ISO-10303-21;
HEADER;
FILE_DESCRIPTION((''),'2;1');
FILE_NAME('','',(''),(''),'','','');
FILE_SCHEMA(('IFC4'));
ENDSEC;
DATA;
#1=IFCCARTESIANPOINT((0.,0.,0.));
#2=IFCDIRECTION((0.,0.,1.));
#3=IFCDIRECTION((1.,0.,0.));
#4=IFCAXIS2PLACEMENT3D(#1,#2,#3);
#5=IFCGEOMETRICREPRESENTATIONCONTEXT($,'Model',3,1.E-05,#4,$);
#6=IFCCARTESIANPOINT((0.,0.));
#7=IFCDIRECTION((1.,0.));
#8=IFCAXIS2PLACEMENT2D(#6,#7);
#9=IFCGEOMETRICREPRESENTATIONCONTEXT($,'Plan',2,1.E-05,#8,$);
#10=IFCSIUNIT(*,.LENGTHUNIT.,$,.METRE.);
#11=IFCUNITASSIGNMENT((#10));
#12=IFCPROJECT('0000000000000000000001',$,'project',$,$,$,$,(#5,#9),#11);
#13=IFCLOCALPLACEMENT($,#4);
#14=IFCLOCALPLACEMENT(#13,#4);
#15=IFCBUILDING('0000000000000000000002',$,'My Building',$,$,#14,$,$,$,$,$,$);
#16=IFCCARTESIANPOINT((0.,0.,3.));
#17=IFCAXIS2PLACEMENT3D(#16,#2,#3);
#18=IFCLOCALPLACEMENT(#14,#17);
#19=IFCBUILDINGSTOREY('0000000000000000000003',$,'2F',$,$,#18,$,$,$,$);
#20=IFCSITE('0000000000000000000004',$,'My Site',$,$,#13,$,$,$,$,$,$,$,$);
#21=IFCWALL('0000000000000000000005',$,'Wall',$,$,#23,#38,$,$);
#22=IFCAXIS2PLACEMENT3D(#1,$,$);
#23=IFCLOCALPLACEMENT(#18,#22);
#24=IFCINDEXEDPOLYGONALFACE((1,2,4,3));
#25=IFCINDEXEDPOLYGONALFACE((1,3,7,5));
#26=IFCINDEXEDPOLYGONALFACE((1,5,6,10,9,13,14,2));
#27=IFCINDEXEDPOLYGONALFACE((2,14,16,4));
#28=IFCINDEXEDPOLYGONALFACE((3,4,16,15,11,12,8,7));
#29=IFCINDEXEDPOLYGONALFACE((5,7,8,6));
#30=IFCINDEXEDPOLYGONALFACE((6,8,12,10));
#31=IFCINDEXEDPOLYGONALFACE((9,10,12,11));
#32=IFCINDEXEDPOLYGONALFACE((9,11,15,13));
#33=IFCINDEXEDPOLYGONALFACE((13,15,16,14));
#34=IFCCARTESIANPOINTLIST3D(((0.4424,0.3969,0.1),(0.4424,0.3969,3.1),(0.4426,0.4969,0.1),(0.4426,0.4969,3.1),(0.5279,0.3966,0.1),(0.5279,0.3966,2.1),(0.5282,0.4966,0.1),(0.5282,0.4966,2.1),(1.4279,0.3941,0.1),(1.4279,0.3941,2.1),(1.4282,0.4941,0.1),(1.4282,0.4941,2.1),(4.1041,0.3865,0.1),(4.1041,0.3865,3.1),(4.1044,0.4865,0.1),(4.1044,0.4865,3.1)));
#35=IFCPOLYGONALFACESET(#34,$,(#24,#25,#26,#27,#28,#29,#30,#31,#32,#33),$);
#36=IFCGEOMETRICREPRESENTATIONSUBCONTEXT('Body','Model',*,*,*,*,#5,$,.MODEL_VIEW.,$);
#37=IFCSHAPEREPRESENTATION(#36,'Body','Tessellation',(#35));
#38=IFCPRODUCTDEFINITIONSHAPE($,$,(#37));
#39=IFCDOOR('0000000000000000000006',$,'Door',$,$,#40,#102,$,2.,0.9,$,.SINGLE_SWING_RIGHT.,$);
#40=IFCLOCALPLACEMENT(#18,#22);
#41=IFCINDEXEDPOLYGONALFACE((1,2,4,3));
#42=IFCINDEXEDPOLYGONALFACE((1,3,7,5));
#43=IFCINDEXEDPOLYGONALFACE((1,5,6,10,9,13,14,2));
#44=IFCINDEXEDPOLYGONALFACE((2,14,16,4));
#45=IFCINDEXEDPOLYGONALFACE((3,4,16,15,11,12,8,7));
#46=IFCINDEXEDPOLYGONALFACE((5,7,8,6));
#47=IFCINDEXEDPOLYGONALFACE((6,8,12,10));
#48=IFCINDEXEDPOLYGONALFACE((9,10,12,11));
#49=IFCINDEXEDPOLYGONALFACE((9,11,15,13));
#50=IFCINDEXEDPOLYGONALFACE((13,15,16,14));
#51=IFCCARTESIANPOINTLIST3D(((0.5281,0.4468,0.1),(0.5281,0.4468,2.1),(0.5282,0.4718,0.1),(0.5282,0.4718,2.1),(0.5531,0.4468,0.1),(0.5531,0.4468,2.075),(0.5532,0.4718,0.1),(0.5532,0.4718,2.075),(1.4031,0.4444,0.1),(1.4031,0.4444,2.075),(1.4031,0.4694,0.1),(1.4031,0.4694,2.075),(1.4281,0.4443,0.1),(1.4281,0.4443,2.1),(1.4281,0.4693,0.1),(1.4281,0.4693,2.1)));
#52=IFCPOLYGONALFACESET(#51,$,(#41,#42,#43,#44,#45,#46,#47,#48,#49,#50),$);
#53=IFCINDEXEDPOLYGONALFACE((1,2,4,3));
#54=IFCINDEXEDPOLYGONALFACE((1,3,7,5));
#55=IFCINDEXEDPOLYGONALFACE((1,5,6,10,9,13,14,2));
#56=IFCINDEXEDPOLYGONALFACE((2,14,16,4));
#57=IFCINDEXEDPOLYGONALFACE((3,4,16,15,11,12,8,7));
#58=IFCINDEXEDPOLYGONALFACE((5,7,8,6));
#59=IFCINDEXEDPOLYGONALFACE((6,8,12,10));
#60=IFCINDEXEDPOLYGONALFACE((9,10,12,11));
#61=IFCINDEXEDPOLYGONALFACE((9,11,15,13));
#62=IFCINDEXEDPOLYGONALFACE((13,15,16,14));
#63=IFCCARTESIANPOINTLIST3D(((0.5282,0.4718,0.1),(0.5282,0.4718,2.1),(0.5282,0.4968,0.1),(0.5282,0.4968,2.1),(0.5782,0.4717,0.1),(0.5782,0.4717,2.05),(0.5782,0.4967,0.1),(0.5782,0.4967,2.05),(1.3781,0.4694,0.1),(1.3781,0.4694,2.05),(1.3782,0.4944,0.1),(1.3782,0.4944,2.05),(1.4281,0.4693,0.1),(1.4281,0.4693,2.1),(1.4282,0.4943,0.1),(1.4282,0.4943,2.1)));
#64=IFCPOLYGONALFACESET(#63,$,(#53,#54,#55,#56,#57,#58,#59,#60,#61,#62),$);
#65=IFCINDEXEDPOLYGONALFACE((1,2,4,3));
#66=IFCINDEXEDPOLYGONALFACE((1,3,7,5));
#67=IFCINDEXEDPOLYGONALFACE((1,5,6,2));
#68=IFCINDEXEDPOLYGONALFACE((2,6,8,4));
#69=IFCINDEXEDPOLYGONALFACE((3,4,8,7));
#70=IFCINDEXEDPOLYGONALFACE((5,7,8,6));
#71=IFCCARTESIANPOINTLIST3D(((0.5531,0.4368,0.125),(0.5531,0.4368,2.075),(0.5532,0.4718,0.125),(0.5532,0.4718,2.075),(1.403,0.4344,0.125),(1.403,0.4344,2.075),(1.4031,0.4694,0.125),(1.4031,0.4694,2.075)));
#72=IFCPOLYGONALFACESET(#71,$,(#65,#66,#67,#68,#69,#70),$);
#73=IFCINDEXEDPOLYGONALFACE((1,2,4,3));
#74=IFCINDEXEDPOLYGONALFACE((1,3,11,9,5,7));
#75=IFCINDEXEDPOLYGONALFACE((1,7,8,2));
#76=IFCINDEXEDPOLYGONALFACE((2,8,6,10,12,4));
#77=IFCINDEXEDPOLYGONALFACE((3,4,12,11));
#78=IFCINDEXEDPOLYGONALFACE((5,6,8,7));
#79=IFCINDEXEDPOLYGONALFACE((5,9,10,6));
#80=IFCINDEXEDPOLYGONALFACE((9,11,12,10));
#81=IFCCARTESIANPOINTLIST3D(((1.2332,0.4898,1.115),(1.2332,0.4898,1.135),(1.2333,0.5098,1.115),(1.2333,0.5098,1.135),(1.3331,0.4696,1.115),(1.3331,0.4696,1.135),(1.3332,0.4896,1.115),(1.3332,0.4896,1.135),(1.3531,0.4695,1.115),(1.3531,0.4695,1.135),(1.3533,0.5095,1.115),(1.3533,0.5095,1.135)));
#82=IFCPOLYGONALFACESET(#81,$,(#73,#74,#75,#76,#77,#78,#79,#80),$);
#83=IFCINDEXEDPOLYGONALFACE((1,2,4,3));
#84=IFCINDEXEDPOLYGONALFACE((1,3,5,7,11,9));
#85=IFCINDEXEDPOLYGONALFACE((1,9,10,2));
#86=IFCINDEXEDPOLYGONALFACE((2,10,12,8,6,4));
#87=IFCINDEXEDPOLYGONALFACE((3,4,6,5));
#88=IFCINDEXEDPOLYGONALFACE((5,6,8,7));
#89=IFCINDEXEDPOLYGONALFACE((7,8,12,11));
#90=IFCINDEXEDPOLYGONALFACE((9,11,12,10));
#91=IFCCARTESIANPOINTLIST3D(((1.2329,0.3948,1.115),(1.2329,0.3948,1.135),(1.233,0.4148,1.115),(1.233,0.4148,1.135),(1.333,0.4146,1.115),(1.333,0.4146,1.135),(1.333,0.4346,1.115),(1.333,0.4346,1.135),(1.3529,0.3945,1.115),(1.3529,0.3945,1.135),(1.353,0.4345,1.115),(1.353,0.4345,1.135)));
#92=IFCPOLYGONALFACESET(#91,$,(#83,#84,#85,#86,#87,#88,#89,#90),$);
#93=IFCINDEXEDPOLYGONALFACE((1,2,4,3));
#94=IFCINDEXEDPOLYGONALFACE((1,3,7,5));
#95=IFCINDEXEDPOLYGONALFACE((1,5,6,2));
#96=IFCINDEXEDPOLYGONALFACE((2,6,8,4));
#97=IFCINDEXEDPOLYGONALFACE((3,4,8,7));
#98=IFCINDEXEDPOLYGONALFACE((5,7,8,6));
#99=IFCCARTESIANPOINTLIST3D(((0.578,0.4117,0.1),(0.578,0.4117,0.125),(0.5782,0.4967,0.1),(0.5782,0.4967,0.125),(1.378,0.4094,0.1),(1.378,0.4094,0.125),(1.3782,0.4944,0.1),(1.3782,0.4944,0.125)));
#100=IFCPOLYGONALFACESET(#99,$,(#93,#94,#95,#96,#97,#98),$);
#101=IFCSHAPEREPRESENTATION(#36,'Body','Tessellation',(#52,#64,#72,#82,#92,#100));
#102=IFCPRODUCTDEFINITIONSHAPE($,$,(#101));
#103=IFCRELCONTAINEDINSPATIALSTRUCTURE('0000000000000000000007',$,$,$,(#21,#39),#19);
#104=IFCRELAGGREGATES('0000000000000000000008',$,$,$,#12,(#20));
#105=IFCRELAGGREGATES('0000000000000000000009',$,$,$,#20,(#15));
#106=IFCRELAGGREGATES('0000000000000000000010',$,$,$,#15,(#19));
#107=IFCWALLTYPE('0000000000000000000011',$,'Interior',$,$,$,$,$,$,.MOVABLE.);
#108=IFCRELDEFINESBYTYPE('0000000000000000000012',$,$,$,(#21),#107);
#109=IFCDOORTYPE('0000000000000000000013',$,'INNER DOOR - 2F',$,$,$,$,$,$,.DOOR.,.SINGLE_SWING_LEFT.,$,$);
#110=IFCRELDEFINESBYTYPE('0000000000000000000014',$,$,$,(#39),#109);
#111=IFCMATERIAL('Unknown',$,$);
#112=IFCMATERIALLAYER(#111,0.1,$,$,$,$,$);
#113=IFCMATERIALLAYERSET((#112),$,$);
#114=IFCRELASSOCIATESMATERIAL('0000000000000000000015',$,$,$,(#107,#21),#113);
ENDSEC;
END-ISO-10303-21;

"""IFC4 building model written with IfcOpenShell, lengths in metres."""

from ifc_helpers import new_model, entity, si_unit, frame, origin_with_axes, origin_2d_with_axis, place, context, subcontext, project, spatial, line, indexed_curve, outline, extrude, shape, source, transform, mapped, material, layer, layer_set, layer_usage, type_object, type_shapes, element, fill, save


model = new_model("IFC4")

# Units and contexts
model_context = context("Model", 3, precision=1e-05, world=origin_with_axes())
plan_context = context("Plan", 2, precision=1e-05, world=origin_2d_with_axis())
body_context_1 = subcontext(model_context, "Body", "Model", "MODEL_VIEW")
body_context_2 = subcontext(plan_context, "Body", "Plan", "PLAN_VIEW")
ifc_project = project(units=[si_unit("LENGTHUNIT", "METRE")], contexts=[model_context, plan_context])

# Site, building, storey
site_placement = place(None, origin_with_axes())
site = spatial("IfcSite", under=ifc_project, at=site_placement, Name="My Site")
building_placement = place(site_placement, origin_with_axes())
building = spatial("IfcBuilding", under=site, at=building_placement, Name="My Building")
storey_placement = place(building_placement, frame((0.0, 0.0, 3.0), z_axis=(0.0, 0.0, 1.0), x_axis=(1.0, 0.0, 0.0)))
storey = spatial("IfcBuildingStorey", under=building, at=storey_placement, Name="2F")

# Shared definitions
ifc_material = material(Name="Unknown")

# Shared definitions
ifc_layer_1 = layer(ifc_material, 0.1)
ifc_layer_set_1 = layer_set([ifc_layer_1])
wall_type_1 = type_object("IfcWallType", Name="Interior", PredefinedType="MOVABLE", material=ifc_layer_set_1)
shared_shape_1 = source(origin_with_axes(), body_context_1, "Body", "SweptSolid", [
    extrude(outline(indexed_curve([(0.0, 0.0), (0.9, 0.0), (0.9, 2.0), (0.0, 2.0)], segments=[line(1, 2, 3, 4, 1)])), frame((0.0, -0.6, 0.0), z_axis=(0.0, -1.0, 0.0), x_axis=(1.0, 0.0, 0.0)), (0.0, 0.0, -1.0), 1.2),
])
door_type_1 = type_object("IfcDoorType", Name="INNER DOOR - 2F", OperationType="SINGLE_SWING_LEFT", PredefinedType="DOOR")
shared_shape_2 = source(origin_with_axes(), body_context_1, "Body", "SweptSolid", [
    extrude(outline(indexed_curve([(0.0, 0.0), (0.0, 2.0), (0.9, 2.0), (0.9, 0.0), (0.875, 0.0), (0.875, 1.975), (0.025, 1.975), (0.025, 0.0)], segments=[line(1, 2, 3, 4, 5, 6, 7, 8, 1)])), frame((0.0, 0.025, 0.0), z_axis=(0.0, -1.0, 0.0), x_axis=(1.0, 0.0, 0.0)), (0.0, 0.0, -1.0), 0.025),
    extrude(outline(indexed_curve([(0.0, 0.0), (0.0, 2.0), (0.9, 2.0), (0.9, 0.0), (0.85, 0.0), (0.85, 1.95), (0.05, 1.95), (0.05, 0.0)], segments=[line(1, 2, 3, 4, 5, 6, 7, 8, 1)])), frame((0.0, 0.0, 0.0), z_axis=(0.0, -1.0, 0.0), x_axis=(1.0, 0.0, 0.0)), (0.0, 0.0, -1.0), 0.025),
    extrude(outline(indexed_curve([(0.0, 0.0), (0.85, 0.0), (0.85, 0.035), (0.0, 0.035)], segments=[line(1, 2, 3, 4, 1)])), frame((0.025, 0.025, 0.025), z_axis=(0.0, 0.0, 1.0), x_axis=(1.0, 0.0, 0.0)), (0.0, 0.0, 1.0), 1.95),
    extrude(outline(indexed_curve([(0.0, 0.0), (0.0, -0.04), (0.12, -0.04), (0.12, -0.02), (0.02, -0.02), (0.02, 0.0)], segments=[line(1, 2, 3, 4, 5, 6, 1)])), frame((0.075, 0.025, 1.015), z_axis=(0.0, 0.0, 1.0), x_axis=(1.0, 0.0, 0.0)), (0.0, 0.0, 1.0), 0.02),
    extrude(outline(indexed_curve([(0.0, 0.0), (0.0, 0.04), (0.12, 0.04), (0.12, 0.02), (0.02, 0.02), (0.02, 0.0)], segments=[line(1, 2, 3, 4, 5, 6, 1)])), frame((0.075, 0.06, 1.015), z_axis=(0.0, 0.0, 1.0), x_axis=(1.0, 0.0, 0.0)), (0.0, 0.0, 1.0), 0.02),
    extrude(outline(indexed_curve([(0.0, 0.0), (0.8, 0.0), (0.8, 0.085), (0.0, 0.085)], segments=[line(1, 2, 3, 4, 1)])), frame((0.05, 0.0, 0.0), z_axis=(0.0, 0.0, 1.0), x_axis=(1.0, 0.0, 0.0)), (0.0, 0.0, 1.0), 0.025),
])
shared_shape_3 = source(origin_with_axes(), body_context_2, "Body", "Curve2D", [
    entity("IfcIndexedPolyCurve", entity("IfcCartesianPointList2D", [[0.0, 0.0], [0.0, 0.05], [0.025, 0.05], [0.025, 0.025], [0.05, 0.025], [0.05, 0.0]]), [entity("IfcLineIndex", [1, 2, 3, 4, 5, 6, 1])]),
    entity("IfcIndexedPolyCurve", entity("IfcCartesianPointList2D", [[0.9, 0.0], [0.9, 0.05], [0.875, 0.05], [0.875, 0.025], [0.85, 0.025], [0.85, 0.0]]), [entity("IfcLineIndex", [1, 2, 3, 4, 5, 6, 1])]),
    entity("IfcTrimmedCurve", entity("IfcEllipse", entity("IfcAxis2Placement2D", entity("IfcCartesianPoint", [0.84, 0.05]), entity("IfcDirection", [1.0, 0.0])), 0.815, 0.85), [entity("IfcCartesianPoint", [0.84, 0.9])], [entity("IfcCartesianPoint", [0.025, 0.05])], True, "CARTESIAN"),
    entity("IfcIndexedPolyCurve", entity("IfcCartesianPointList2D", [[0.875, 0.05], [0.84, 0.05], [0.84, 0.9], [0.875, 0.9]]), [entity("IfcLineIndex", [1, 2, 3, 4, 1])]),
])
type_shapes(door_type_1, [shared_shape_2, shared_shape_3])

# Wall, opening, door
ifc_layer_usage_1 = layer_usage(ifc_layer_set_1, "AXIS2", "POSITIVE", 0.0)
wall_1_placement = place(storey_placement, frame((0.4424, 0.3969, 0.1), z_axis=(0.0, 0.0, 1.0), x_axis=(0.999996, -0.002846, 0.0)))
wall_1 = element("IfcWall", 1, at=wall_1_placement, inside=storey, type_object=wall_type_1, material=ifc_layer_usage_1, Name="Wall", context=body_context_1, shape_type="SweptSolid", body=[
    extrude(outline(indexed_curve([(0.0, 0.0), (0.0, 0.1), (3.6618, 0.1), (3.6618, 0.0)], segments=[line(1, 2, 3, 4, 1)])), origin_with_axes(), (0.0, 0.0, 1.0), 3.0),
])
opening_1_placement = place(wall_1_placement, frame((0.9856, 0.1002, 0.0), z_axis=(0.0, 0.0, 1.0), x_axis=(-1.0, 0.0, 0.0)))
opening_1 = element("IfcOpeningElement", 2, at=opening_1_placement, cuts=wall_1, PredefinedType="OPENING", context=body_context_1, shape_type="MappedRepresentation", body=[
    mapped(shared_shape_1, transform((0.0, 0.0, 0.0), x_axis=(1.0, 0.0, 0.0), y_axis=(0.0, 1.0, 0.0), z_axis=(0.0, 0.0, 1.0), scale=1.0)),
])
door_1_placement = place(opening_1_placement, frame((0.0, 0.0, 0.0), z_axis=(0.0, 0.0, 1.0), x_axis=(1.0, 0.0, 0.0)))
door_1 = element("IfcDoor", 3, at=door_1_placement, inside=storey, type_object=door_type_1, Name="Door", OperationType="SINGLE_SWING_RIGHT", OverallHeight=2.0, OverallWidth=0.9, shapes=[
    shape(body_context_1, "Body", "MappedRepresentation", [mapped(shared_shape_2, transform((0.0, 0.0, 0.0), x_axis=(1.0, 0.0, 0.0), y_axis=(0.0, 1.0, 0.0), z_axis=(0.0, 0.0, 1.0), scale=1.0))]),
    shape(body_context_2, "Body", "MappedRepresentation", [mapped(shared_shape_3, transform((0.0, 0.0, 0.0), x_axis=(1.0, 0.0, 0.0), y_axis=(0.0, 1.0, 0.0), z_axis=(0.0, 0.0, 1.0), scale=1.0))]),
])
fill(opening_1, door_1)

save(model, "model.ifc")
